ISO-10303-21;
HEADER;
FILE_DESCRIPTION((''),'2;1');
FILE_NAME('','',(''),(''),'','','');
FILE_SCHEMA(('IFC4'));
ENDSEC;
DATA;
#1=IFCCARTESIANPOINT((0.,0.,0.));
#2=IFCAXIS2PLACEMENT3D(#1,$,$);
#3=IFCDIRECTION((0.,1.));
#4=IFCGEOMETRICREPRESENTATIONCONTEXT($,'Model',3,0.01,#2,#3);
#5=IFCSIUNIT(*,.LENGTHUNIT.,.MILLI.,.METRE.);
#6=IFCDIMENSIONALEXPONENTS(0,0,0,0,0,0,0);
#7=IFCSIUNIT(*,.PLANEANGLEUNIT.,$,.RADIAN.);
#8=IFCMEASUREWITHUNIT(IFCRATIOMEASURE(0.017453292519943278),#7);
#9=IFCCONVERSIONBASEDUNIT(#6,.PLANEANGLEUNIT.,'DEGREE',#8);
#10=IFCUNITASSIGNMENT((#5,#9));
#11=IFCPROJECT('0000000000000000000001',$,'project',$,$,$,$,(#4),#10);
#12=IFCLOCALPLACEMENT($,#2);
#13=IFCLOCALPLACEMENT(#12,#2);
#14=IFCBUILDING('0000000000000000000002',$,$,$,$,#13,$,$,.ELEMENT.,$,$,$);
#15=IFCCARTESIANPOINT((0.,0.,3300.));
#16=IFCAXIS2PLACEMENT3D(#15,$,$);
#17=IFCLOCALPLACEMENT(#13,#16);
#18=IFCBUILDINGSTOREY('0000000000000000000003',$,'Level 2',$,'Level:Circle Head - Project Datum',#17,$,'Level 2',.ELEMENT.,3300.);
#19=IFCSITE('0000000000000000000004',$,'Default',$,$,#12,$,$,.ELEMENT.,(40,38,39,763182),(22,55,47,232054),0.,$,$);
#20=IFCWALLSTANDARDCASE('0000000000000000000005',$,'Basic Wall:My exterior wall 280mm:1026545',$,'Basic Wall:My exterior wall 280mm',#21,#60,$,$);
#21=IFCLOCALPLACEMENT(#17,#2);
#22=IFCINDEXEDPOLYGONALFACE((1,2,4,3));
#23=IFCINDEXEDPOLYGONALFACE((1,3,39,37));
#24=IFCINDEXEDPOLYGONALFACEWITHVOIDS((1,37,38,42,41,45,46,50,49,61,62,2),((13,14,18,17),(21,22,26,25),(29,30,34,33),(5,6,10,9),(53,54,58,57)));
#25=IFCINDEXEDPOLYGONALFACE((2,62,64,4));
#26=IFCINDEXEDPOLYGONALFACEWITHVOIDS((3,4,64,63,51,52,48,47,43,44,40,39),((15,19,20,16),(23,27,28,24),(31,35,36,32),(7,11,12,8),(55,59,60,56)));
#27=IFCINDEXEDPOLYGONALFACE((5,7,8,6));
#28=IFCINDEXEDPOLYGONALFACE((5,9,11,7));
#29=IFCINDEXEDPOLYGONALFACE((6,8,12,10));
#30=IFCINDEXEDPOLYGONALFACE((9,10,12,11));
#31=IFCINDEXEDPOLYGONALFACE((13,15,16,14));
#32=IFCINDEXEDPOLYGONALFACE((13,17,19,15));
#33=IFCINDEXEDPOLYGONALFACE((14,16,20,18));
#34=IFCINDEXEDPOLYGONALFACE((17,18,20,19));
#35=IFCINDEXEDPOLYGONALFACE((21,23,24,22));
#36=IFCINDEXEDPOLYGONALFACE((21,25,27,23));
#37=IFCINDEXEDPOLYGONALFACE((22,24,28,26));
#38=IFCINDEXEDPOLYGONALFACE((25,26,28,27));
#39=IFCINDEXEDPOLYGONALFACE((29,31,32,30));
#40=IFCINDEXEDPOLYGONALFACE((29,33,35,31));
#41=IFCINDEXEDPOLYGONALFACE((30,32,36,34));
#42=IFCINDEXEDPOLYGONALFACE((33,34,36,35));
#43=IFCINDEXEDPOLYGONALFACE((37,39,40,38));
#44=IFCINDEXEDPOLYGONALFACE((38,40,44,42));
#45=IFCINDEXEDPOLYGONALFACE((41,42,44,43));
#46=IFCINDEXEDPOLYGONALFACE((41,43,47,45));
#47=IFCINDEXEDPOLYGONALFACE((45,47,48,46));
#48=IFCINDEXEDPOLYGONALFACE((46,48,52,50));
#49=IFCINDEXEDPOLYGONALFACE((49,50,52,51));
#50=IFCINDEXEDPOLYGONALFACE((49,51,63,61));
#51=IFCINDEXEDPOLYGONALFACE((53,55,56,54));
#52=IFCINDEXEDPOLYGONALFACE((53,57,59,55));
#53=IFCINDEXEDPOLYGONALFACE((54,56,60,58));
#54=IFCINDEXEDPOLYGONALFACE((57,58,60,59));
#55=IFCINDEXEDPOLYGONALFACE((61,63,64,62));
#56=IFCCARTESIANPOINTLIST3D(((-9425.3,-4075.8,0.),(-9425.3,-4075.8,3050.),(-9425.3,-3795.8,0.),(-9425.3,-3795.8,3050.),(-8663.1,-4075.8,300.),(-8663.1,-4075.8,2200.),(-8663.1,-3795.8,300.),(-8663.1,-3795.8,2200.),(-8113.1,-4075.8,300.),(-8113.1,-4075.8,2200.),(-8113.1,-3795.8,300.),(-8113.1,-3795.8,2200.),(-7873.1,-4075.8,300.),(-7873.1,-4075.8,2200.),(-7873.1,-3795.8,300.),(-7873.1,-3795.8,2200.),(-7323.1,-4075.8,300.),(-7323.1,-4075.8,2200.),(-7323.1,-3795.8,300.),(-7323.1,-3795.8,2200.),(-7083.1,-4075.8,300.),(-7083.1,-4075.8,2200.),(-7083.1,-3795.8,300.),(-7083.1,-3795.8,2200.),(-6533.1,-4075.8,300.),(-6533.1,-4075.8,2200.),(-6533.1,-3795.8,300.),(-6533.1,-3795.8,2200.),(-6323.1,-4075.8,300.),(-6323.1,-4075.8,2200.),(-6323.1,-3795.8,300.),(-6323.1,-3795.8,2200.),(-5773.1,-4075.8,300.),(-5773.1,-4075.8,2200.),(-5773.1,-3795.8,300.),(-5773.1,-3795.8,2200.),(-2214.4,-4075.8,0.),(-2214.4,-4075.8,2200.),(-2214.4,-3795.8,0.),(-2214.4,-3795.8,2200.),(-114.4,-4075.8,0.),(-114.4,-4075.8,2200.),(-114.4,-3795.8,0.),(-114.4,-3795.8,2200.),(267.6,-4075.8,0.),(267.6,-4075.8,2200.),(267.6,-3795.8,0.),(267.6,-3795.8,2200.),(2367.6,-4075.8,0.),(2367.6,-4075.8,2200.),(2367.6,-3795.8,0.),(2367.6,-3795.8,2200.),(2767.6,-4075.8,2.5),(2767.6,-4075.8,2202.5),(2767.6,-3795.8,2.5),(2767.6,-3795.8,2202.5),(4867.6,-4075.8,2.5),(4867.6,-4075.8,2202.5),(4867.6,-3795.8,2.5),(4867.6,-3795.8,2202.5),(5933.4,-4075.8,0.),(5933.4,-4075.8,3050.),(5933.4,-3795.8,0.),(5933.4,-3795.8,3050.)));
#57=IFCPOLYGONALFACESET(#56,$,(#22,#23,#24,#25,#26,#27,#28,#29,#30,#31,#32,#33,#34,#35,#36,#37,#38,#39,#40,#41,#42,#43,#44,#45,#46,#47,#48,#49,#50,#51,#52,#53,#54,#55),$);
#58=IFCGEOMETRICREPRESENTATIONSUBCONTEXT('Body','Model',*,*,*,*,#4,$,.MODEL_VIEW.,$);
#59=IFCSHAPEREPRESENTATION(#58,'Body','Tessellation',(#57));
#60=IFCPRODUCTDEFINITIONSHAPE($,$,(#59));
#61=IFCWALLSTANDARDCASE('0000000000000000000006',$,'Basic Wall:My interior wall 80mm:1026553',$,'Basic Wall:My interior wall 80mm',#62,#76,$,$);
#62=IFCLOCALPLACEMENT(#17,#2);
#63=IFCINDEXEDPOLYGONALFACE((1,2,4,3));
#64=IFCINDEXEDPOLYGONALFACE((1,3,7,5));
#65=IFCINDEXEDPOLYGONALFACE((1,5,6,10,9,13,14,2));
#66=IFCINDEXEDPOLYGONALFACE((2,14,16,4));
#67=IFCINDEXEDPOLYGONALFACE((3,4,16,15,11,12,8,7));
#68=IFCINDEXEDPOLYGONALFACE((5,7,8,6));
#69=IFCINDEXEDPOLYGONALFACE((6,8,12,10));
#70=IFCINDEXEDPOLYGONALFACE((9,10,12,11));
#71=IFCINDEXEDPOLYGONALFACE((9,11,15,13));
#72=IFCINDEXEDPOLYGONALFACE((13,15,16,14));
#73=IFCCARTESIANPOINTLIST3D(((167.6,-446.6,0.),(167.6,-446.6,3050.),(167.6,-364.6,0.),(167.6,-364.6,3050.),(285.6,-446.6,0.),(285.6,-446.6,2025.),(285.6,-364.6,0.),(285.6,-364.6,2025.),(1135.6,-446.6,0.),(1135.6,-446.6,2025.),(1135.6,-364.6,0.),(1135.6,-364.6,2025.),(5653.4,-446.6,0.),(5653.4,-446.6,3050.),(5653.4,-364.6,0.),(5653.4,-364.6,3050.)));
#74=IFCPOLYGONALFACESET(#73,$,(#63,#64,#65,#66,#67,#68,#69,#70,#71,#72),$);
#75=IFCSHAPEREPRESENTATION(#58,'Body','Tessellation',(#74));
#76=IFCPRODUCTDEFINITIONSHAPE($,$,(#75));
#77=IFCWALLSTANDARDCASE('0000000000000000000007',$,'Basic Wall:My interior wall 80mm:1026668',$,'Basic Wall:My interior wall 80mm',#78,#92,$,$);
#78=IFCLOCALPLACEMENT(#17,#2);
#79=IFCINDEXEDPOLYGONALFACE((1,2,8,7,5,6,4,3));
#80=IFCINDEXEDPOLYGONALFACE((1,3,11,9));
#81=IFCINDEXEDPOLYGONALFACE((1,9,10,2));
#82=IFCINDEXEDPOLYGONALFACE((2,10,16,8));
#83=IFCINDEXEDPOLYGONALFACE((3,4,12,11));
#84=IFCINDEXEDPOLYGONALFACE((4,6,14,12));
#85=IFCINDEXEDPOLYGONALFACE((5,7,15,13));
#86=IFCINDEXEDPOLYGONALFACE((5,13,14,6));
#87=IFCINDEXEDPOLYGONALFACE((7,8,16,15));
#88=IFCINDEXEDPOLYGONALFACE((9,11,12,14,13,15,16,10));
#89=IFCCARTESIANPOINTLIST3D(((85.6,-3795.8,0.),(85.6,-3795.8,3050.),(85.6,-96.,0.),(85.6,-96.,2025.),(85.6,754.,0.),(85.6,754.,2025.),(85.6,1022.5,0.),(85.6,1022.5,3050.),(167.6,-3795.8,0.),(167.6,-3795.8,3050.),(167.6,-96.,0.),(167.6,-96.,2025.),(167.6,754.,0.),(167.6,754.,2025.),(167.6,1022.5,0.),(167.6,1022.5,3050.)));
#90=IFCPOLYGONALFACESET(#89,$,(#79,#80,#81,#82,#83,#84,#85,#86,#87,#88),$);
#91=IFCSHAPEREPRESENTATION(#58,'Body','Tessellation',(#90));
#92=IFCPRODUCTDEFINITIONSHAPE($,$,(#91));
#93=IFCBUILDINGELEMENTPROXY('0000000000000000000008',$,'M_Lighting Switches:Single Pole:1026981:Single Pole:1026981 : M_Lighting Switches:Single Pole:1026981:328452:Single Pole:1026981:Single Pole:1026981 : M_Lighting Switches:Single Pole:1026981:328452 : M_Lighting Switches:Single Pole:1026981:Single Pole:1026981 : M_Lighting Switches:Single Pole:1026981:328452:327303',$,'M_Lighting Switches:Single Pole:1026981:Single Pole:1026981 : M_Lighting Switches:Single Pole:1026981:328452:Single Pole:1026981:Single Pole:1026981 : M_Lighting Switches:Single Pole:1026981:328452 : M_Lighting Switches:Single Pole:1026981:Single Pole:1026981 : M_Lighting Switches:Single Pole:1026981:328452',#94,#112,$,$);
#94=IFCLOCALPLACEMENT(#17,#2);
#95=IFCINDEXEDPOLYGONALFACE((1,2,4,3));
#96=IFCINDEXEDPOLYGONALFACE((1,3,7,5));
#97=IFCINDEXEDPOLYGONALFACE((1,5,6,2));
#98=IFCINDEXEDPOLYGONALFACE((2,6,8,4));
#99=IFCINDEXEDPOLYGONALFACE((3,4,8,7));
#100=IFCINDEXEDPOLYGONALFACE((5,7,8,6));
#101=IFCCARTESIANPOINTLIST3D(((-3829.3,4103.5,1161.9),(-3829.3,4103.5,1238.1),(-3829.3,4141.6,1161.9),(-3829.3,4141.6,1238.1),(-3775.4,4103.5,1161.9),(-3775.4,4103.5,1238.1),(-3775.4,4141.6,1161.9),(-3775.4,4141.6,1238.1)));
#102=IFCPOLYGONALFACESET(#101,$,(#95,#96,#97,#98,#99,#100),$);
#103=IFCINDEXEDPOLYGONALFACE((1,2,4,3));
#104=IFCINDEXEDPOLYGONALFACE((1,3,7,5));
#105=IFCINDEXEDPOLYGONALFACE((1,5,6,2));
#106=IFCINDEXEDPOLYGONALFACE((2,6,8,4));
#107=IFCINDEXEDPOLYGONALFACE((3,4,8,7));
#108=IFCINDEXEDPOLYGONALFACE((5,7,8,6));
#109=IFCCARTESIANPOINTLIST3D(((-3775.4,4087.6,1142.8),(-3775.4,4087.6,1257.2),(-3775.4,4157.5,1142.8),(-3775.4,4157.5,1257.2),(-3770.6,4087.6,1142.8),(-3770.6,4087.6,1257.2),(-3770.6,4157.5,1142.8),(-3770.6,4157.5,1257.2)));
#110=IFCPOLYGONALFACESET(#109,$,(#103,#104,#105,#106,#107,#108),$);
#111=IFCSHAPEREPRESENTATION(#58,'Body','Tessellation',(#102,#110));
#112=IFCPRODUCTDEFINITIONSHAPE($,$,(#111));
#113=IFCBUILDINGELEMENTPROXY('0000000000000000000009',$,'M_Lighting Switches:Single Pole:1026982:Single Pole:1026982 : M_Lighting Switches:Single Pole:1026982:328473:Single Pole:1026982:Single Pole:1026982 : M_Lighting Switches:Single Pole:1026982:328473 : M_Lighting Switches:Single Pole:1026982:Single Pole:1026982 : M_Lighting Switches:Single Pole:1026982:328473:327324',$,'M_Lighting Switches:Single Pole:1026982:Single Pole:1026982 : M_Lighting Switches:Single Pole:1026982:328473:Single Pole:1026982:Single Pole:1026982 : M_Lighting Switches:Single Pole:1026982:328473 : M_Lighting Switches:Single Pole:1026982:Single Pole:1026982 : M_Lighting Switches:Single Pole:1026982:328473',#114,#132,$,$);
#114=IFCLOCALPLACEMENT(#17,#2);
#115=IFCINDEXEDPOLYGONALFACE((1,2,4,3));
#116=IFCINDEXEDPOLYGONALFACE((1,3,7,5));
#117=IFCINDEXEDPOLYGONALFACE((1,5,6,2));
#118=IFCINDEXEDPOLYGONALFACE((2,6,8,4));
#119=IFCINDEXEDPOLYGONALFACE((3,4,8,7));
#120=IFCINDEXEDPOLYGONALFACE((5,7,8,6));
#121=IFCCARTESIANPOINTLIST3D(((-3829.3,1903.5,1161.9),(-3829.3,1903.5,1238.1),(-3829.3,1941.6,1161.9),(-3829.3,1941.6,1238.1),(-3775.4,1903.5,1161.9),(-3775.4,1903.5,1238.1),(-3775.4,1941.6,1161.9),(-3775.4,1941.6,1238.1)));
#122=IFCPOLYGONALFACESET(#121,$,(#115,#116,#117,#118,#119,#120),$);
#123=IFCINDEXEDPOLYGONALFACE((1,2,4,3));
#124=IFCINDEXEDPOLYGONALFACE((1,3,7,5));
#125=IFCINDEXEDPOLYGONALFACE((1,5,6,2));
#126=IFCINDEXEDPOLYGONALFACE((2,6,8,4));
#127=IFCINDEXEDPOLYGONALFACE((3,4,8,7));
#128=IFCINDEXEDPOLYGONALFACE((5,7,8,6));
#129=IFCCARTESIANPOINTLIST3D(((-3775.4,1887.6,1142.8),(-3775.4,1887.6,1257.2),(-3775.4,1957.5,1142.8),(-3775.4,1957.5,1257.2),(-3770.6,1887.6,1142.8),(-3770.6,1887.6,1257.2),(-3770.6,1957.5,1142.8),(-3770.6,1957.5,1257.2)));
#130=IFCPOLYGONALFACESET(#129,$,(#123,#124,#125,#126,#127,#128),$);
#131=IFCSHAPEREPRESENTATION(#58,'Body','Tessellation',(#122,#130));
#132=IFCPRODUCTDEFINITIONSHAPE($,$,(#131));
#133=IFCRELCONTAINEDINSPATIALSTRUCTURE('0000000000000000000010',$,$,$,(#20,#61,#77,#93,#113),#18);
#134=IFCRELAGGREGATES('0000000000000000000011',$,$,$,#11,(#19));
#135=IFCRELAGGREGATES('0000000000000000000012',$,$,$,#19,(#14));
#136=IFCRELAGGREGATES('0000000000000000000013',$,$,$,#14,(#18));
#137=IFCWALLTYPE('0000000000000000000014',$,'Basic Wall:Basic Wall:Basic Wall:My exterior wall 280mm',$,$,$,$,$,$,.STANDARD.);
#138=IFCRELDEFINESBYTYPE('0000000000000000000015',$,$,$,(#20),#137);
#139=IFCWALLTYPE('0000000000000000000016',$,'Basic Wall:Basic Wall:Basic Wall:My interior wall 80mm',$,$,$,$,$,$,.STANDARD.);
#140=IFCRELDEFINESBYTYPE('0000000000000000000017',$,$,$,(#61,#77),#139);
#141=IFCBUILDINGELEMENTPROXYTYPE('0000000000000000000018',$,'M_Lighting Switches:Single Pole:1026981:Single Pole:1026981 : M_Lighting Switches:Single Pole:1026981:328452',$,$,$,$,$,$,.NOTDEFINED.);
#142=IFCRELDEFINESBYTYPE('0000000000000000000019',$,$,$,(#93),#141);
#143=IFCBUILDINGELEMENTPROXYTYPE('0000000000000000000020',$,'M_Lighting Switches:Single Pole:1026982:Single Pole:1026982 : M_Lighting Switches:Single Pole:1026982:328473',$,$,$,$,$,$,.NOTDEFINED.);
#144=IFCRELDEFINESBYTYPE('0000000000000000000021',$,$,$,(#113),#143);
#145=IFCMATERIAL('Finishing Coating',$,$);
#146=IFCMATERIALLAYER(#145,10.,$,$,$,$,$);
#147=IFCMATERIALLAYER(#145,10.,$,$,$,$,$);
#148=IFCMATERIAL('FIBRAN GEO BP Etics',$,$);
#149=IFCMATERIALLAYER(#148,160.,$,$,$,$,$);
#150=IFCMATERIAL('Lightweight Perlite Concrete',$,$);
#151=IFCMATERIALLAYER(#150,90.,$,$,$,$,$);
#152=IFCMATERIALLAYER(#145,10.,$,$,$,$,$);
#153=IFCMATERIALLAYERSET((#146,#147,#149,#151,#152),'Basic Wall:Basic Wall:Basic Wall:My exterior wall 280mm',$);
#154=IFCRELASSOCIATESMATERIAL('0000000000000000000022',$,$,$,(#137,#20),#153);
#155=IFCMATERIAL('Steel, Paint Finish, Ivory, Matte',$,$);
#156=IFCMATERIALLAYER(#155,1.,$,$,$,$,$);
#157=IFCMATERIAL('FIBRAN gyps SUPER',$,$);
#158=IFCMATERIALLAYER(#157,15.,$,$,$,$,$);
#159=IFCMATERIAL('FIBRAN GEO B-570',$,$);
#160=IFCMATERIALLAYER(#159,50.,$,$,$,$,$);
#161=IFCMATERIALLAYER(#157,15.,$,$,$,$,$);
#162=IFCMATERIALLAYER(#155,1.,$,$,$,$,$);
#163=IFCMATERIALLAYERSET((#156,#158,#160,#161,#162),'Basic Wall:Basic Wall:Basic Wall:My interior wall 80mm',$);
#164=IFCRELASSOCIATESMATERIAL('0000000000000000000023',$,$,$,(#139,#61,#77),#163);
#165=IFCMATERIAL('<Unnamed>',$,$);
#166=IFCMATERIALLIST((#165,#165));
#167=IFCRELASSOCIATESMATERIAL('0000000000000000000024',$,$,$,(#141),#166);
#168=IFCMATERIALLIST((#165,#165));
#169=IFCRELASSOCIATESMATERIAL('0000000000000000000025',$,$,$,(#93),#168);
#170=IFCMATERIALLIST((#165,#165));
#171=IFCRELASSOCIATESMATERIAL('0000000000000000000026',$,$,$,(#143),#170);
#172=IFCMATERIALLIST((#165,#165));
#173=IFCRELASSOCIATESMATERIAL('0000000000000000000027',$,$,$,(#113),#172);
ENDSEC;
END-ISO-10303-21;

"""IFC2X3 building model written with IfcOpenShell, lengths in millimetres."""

from ifc_helpers import new_model, entity, si_unit, converted_unit, direction, frame, frame_2d, origin, origin_2d_with_axis, place, context, subcontext, project, spatial, rectangle, extrude, source, transform, mapped, material, material_list, layer, layer_set, layer_usage, type_object, type_shapes, element, save


model = new_model("IFC2X3")

# Units and contexts
model_context = context("Model", 3, precision=0.01, world=origin(), true_north=direction((0.0, 1.0)))
body_context = subcontext(model_context, "Body", "Model", "MODEL_VIEW")
ifc_project = project(units=[si_unit("LENGTHUNIT", "METRE", prefix="MILLI"), converted_unit("PLANEANGLEUNIT", "DEGREE", entity("IfcRatioMeasure", 0.017453292519943278), si_unit("PLANEANGLEUNIT", "RADIAN"), dimensions=[0, 0, 0, 0, 0, 0, 0])], contexts=[model_context])

# Site, building, storey
site_placement = place(None, origin())
site = spatial("IfcSite", under=ifc_project, at=site_placement, Name="Default", CompositionType="ELEMENT", RefLatitude=(40, 38, 39, 763182), RefLongitude=(22, 55, 47, 232054), RefElevation=0.0)
building_placement = place(site_placement, origin())
building = spatial("IfcBuilding", under=site, at=building_placement, CompositionType="ELEMENT")
storey_placement = place(building_placement, frame((0.0, 0.0, 3300.0)))
storey = spatial("IfcBuildingStorey", under=building, at=storey_placement, Name="Level 2", ObjectType="Level:Circle Head - Project Datum", LongName="Level 2", CompositionType="ELEMENT", Elevation=3300.0)

# Wall, openings
ifc_material_1 = material(Name="Finishing Coating")
ifc_layer_1 = layer(ifc_material_1, 10.0)
ifc_layer_2 = layer(ifc_material_1, 10.0)
ifc_material_2 = material(Name="FIBRAN GEO BP Etics")
ifc_layer_3 = layer(ifc_material_2, 160.0)
ifc_material_3 = material(Name="Lightweight Perlite Concrete")
ifc_layer_4 = layer(ifc_material_3, 90.0)
ifc_layer_5 = layer(ifc_material_1, 10.0)
ifc_layer_set_1 = layer_set([ifc_layer_1, ifc_layer_2, ifc_layer_3, ifc_layer_4, ifc_layer_5], Name="Basic Wall:Basic Wall:Basic Wall:My exterior wall 280mm")
ifc_layer_usage_1 = layer_usage(ifc_layer_set_1, "AXIS2", "NEGATIVE", 140.0)
wall_type_1 = type_object("IfcWallType", Name="Basic Wall:Basic Wall:Basic Wall:My exterior wall 280mm", PredefinedType="STANDARD", material=ifc_layer_set_1)
wall_1_placement = place(storey_placement, frame((5933.4, -3935.8, 0.0), z_axis=(0.0, 0.0, 1.0), x_axis=(-1.0, 0.0, 0.0)))
wall_1 = element("IfcWallStandardCase", 1, at=wall_1_placement, inside=storey, type_object=wall_type_1, material=ifc_layer_usage_1, Name="Basic Wall:My exterior wall 280mm:1026545", ObjectType="Basic Wall:My exterior wall 280mm", context=body_context, shape_type="SweptSolid", body=[
    extrude(rectangle(XDim=15358.7, YDim=280.0, at=frame_2d((7679.4, 0.0), x_axis=(1.0, 0.0))), origin(), (0.0, 0.0, 1.0), 3050.0),
])
opening_1_placement = place(wall_1_placement, origin())
element("IfcOpeningElement", 2, at=opening_1_placement, cuts=wall_1, ObjectType="Opening", context=body_context, shape_type="SweptSolid", body=[
    extrude(rectangle(XDim=2200.0, YDim=2100.0, at=frame_2d((0.0, 0.0), x_axis=(1.0, 0.0))), frame((7097.8, -140.0, 1100.0), z_axis=(0.0, 1.0, 0.0), x_axis=(0.0, 0.0, -1.0)), (0.0, 0.0, 1.0), 280.0),
])
opening_2_placement = place(wall_1_placement, origin())
element("IfcOpeningElement", 3, at=opening_2_placement, cuts=wall_1, ObjectType="Opening", context=body_context, shape_type="SweptSolid", body=[
    extrude(rectangle(XDim=2200.0, YDim=2100.0, at=frame_2d((0.0, 0.0), x_axis=(1.0, 0.0))), frame((4615.8, -140.0, 1100.0), z_axis=(0.0, 1.0, 0.0), x_axis=(0.0, 0.0, -1.0)), (0.0, 0.0, 1.0), 280.0),
])
opening_3_placement = place(wall_1_placement, origin())
element("IfcOpeningElement", 4, at=opening_3_placement, cuts=wall_1, ObjectType="Opening", context=body_context, shape_type="SweptSolid", body=[
    extrude(rectangle(XDim=2200.0, YDim=2100.0, at=frame_2d((0.0, 0.0), x_axis=(1.0, 0.0))), frame((2115.8, -140.0, 1102.5), z_axis=(0.0, 1.0, 0.0), x_axis=(0.0, 0.0, -1.0)), (0.0, 0.0, 1.0), 280.0),
])
opening_4_placement = place(wall_1_placement, origin())
element("IfcOpeningElement", 5, at=opening_4_placement, cuts=wall_1, ObjectType="Opening", context=body_context, shape_type="SweptSolid", body=[
    extrude(rectangle(XDim=1900.0, YDim=550.0, at=frame_2d((0.0, 0.0), x_axis=(1.0, 0.0))), frame((14321.5, -140.0, 1250.0), z_axis=(0.0, 1.0, 0.0), x_axis=(0.0, 0.0, -1.0)), (0.0, 0.0, 1.0), 280.0),
])
opening_5_placement = place(wall_1_placement, origin())
element("IfcOpeningElement", 6, at=opening_5_placement, cuts=wall_1, ObjectType="Opening", context=body_context, shape_type="SweptSolid", body=[
    extrude(rectangle(XDim=1900.0, YDim=550.0, at=frame_2d((0.0, 0.0), x_axis=(1.0, 0.0))), frame((13531.5, -140.0, 1250.0), z_axis=(0.0, 1.0, 0.0), x_axis=(0.0, 0.0, -1.0)), (0.0, 0.0, 1.0), 280.0),
])
opening_6_placement = place(wall_1_placement, origin())
element("IfcOpeningElement", 7, at=opening_6_placement, cuts=wall_1, ObjectType="Opening", context=body_context, shape_type="SweptSolid", body=[
    extrude(rectangle(XDim=1900.0, YDim=550.0, at=frame_2d((0.0, 0.0), x_axis=(1.0, 0.0))), frame((12741.5, -140.0, 1250.0), z_axis=(0.0, 1.0, 0.0), x_axis=(0.0, 0.0, -1.0)), (0.0, 0.0, 1.0), 280.0),
])
opening_7_placement = place(wall_1_placement, origin())
element("IfcOpeningElement", 8, at=opening_7_placement, cuts=wall_1, ObjectType="Opening", context=body_context, shape_type="SweptSolid", body=[
    extrude(rectangle(XDim=1900.0, YDim=550.0, at=frame_2d((0.0, 0.0), x_axis=(1.0, 0.0))), frame((11981.5, -140.0, 1250.0), z_axis=(0.0, 1.0, 0.0), x_axis=(0.0, 0.0, -1.0)), (0.0, 0.0, 1.0), 280.0),
])

# Walls, openings
ifc_material_4 = material(Name="Steel, Paint Finish, Ivory, Matte")
ifc_layer_6 = layer(ifc_material_4, 1.0)
ifc_material_5 = material(Name="FIBRAN gyps SUPER")
ifc_layer_7 = layer(ifc_material_5, 15.0)
ifc_material_6 = material(Name="FIBRAN GEO B-570")
ifc_layer_8 = layer(ifc_material_6, 50.0)
ifc_layer_9 = layer(ifc_material_5, 15.0)
ifc_layer_10 = layer(ifc_material_4, 1.0)
ifc_layer_set_2 = layer_set([ifc_layer_6, ifc_layer_7, ifc_layer_8, ifc_layer_9, ifc_layer_10], Name="Basic Wall:Basic Wall:Basic Wall:My interior wall 80mm")
ifc_layer_usage_2 = layer_usage(ifc_layer_set_2, "AXIS2", "NEGATIVE", 41.0)
wall_type_2 = type_object("IfcWallType", Name="Basic Wall:Basic Wall:Basic Wall:My interior wall 80mm", PredefinedType="STANDARD", material=ifc_layer_set_2)
wall_2_placement = place(storey_placement, frame((5653.4, -405.6, 0.0), z_axis=(0.0, 0.0, 1.0), x_axis=(-1.0, 0.0, 0.0)))
wall_2 = element("IfcWallStandardCase", 9, at=wall_2_placement, inside=storey, type_object=wall_type_2, material=ifc_layer_usage_2, Name="Basic Wall:My interior wall 80mm:1026553", ObjectType="Basic Wall:My interior wall 80mm", context=body_context, shape_type="SweptSolid", body=[
    extrude(rectangle(XDim=5485.8, YDim=82.0, at=frame_2d((2742.9, 0.0), x_axis=(1.0, 0.0))), origin(), (0.0, 0.0, 1.0), 3050.0),
])
opening_8_placement = place(wall_2_placement, origin())
element("IfcOpeningElement", 10, at=opening_8_placement, cuts=wall_2, ObjectType="Opening", context=body_context, shape_type="SweptSolid", body=[
    extrude(rectangle(XDim=2025.0, YDim=850.0, at=frame_2d((0.0, 0.0), x_axis=(1.0, 0.0))), frame((4942.8, -41.0, 1012.5), z_axis=(0.0, 1.0, 0.0), x_axis=(0.0, 0.0, -1.0)), (0.0, 0.0, 1.0), 82.0),
])
ifc_layer_usage_3 = layer_usage(ifc_layer_set_2, "AXIS2", "NEGATIVE", 41.0)
wall_3_placement = place(storey_placement, frame((126.6, -3795.8, 0.0), z_axis=(0.0, 0.0, 1.0), x_axis=(0.0, 1.0, 0.0)))
wall_3 = element("IfcWallStandardCase", 11, at=wall_3_placement, inside=storey, type_object=wall_type_2, material=ifc_layer_usage_3, Name="Basic Wall:My interior wall 80mm:1026668", ObjectType="Basic Wall:My interior wall 80mm", context=body_context, shape_type="SweptSolid", body=[
    extrude(rectangle(XDim=4818.4, YDim=82.0, at=frame_2d((2409.2, 0.0), x_axis=(1.0, 0.0))), origin(), (0.0, 0.0, 1.0), 3050.0),
])
opening_9_placement = place(wall_3_placement, origin())
element("IfcOpeningElement", 12, at=opening_9_placement, cuts=wall_3, ObjectType="Opening", context=body_context, shape_type="SweptSolid", body=[
    extrude(rectangle(XDim=2025.0, YDim=850.0, at=frame_2d((0.0, 0.0), x_axis=(1.0, 0.0))), frame((4124.8, -41.0, 1012.5), z_axis=(0.0, 1.0, 0.0), x_axis=(0.0, 0.0, -1.0)), (0.0, 0.0, 1.0), 82.0),
])

# Shared definitions
ifc_material_7 = material(Name="<Unnamed>")

# Building element proxies
ifc_material_list_1 = material_list([ifc_material_7, ifc_material_7])
ifc_material_list_2 = material_list([ifc_material_7, ifc_material_7])
building_element_proxy_type_1 = type_object("IfcBuildingElementProxyType", Name="M_Lighting Switches:Single Pole:1026981:Single Pole:1026981 : M_Lighting Switches:Single Pole:1026981:328452", PredefinedType="NOTDEFINED", material=ifc_material_list_2)
shared_shape_1 = source(origin(), body_context, "Body", "SweptSolid", [
    extrude(rectangle(XDim=38.1, YDim=54.0, at=origin_2d_with_axis()), frame((-3802.3, 4122.5, 4461.9), z_axis=(0.0, 0.0, 1.0), x_axis=(0.0, -1.0, 0.0)), (0.0, 0.0, 1.0), 76.2),
    extrude(rectangle(XDim=69.8, YDim=4.8, at=origin_2d_with_axis()), frame((-3773.0, 4122.5, 4442.8), z_axis=(0.0, 0.0, 1.0), x_axis=(0.0, -1.0, 0.0)), (0.0, 0.0, 1.0), 114.3),
])
type_shapes(building_element_proxy_type_1, [shared_shape_1])
proxy_1_placement = place(storey_placement, frame((0.0, 0.0, -3300.0)))
element("IfcBuildingElementProxy", 13, at=proxy_1_placement, inside=storey, type_object=building_element_proxy_type_1, material=ifc_material_list_1, Name="M_Lighting Switches:Single Pole:1026981:Single Pole:1026981 : M_Lighting Switches:Single Pole:1026981:328452:Single Pole:1026981:Single Pole:1026981 : M_Lighting Switches:Single Pole:1026981:328452 : M_Lighting Switches:Single Pole:1026981:Single Pole:1026981 : M_Lighting Switches:Single Pole:1026981:328452:327303", ObjectType="M_Lighting Switches:Single Pole:1026981:Single Pole:1026981 : M_Lighting Switches:Single Pole:1026981:328452:Single Pole:1026981:Single Pole:1026981 : M_Lighting Switches:Single Pole:1026981:328452 : M_Lighting Switches:Single Pole:1026981:Single Pole:1026981 : M_Lighting Switches:Single Pole:1026981:328452", context=body_context, shape_type="MappedRepresentation", body=[
    mapped(shared_shape_1, transform((0.0, 0.0, 0.0), scale=1.0)),
])
ifc_material_list_3 = material_list([ifc_material_7, ifc_material_7])
ifc_material_list_4 = material_list([ifc_material_7, ifc_material_7])
building_element_proxy_type_2 = type_object("IfcBuildingElementProxyType", Name="M_Lighting Switches:Single Pole:1026982:Single Pole:1026982 : M_Lighting Switches:Single Pole:1026982:328473", PredefinedType="NOTDEFINED", material=ifc_material_list_4)
shared_shape_2 = source(origin(), body_context, "Body", "SweptSolid", [
    extrude(rectangle(XDim=38.1, YDim=54.0, at=frame_2d((0.0, 0.0), x_axis=(1.0, 0.0))), frame((-3802.3, 1922.5, 4461.9), z_axis=(0.0, 0.0, 1.0), x_axis=(0.0, -1.0, 0.0)), (0.0, 0.0, 1.0), 76.2),
    extrude(rectangle(XDim=69.8, YDim=4.8, at=frame_2d((0.0, 0.0), x_axis=(1.0, 0.0))), frame((-3773.0, 1922.5, 4442.8), z_axis=(0.0, 0.0, 1.0), x_axis=(0.0, -1.0, 0.0)), (0.0, 0.0, 1.0), 114.3),
])
type_shapes(building_element_proxy_type_2, [shared_shape_2])
proxy_2_placement = place(storey_placement, frame((0.0, 0.0, -3300.0)))
element("IfcBuildingElementProxy", 14, at=proxy_2_placement, inside=storey, type_object=building_element_proxy_type_2, material=ifc_material_list_3, Name="M_Lighting Switches:Single Pole:1026982:Single Pole:1026982 : M_Lighting Switches:Single Pole:1026982:328473:Single Pole:1026982:Single Pole:1026982 : M_Lighting Switches:Single Pole:1026982:328473 : M_Lighting Switches:Single Pole:1026982:Single Pole:1026982 : M_Lighting Switches:Single Pole:1026982:328473:327324", ObjectType="M_Lighting Switches:Single Pole:1026982:Single Pole:1026982 : M_Lighting Switches:Single Pole:1026982:328473:Single Pole:1026982:Single Pole:1026982 : M_Lighting Switches:Single Pole:1026982:328473 : M_Lighting Switches:Single Pole:1026982:Single Pole:1026982 : M_Lighting Switches:Single Pole:1026982:328473", context=body_context, shape_type="MappedRepresentation", body=[
    mapped(shared_shape_2, transform((0.0, 0.0, 0.0), scale=1.0)),
])

save(model, "model.ifc")
